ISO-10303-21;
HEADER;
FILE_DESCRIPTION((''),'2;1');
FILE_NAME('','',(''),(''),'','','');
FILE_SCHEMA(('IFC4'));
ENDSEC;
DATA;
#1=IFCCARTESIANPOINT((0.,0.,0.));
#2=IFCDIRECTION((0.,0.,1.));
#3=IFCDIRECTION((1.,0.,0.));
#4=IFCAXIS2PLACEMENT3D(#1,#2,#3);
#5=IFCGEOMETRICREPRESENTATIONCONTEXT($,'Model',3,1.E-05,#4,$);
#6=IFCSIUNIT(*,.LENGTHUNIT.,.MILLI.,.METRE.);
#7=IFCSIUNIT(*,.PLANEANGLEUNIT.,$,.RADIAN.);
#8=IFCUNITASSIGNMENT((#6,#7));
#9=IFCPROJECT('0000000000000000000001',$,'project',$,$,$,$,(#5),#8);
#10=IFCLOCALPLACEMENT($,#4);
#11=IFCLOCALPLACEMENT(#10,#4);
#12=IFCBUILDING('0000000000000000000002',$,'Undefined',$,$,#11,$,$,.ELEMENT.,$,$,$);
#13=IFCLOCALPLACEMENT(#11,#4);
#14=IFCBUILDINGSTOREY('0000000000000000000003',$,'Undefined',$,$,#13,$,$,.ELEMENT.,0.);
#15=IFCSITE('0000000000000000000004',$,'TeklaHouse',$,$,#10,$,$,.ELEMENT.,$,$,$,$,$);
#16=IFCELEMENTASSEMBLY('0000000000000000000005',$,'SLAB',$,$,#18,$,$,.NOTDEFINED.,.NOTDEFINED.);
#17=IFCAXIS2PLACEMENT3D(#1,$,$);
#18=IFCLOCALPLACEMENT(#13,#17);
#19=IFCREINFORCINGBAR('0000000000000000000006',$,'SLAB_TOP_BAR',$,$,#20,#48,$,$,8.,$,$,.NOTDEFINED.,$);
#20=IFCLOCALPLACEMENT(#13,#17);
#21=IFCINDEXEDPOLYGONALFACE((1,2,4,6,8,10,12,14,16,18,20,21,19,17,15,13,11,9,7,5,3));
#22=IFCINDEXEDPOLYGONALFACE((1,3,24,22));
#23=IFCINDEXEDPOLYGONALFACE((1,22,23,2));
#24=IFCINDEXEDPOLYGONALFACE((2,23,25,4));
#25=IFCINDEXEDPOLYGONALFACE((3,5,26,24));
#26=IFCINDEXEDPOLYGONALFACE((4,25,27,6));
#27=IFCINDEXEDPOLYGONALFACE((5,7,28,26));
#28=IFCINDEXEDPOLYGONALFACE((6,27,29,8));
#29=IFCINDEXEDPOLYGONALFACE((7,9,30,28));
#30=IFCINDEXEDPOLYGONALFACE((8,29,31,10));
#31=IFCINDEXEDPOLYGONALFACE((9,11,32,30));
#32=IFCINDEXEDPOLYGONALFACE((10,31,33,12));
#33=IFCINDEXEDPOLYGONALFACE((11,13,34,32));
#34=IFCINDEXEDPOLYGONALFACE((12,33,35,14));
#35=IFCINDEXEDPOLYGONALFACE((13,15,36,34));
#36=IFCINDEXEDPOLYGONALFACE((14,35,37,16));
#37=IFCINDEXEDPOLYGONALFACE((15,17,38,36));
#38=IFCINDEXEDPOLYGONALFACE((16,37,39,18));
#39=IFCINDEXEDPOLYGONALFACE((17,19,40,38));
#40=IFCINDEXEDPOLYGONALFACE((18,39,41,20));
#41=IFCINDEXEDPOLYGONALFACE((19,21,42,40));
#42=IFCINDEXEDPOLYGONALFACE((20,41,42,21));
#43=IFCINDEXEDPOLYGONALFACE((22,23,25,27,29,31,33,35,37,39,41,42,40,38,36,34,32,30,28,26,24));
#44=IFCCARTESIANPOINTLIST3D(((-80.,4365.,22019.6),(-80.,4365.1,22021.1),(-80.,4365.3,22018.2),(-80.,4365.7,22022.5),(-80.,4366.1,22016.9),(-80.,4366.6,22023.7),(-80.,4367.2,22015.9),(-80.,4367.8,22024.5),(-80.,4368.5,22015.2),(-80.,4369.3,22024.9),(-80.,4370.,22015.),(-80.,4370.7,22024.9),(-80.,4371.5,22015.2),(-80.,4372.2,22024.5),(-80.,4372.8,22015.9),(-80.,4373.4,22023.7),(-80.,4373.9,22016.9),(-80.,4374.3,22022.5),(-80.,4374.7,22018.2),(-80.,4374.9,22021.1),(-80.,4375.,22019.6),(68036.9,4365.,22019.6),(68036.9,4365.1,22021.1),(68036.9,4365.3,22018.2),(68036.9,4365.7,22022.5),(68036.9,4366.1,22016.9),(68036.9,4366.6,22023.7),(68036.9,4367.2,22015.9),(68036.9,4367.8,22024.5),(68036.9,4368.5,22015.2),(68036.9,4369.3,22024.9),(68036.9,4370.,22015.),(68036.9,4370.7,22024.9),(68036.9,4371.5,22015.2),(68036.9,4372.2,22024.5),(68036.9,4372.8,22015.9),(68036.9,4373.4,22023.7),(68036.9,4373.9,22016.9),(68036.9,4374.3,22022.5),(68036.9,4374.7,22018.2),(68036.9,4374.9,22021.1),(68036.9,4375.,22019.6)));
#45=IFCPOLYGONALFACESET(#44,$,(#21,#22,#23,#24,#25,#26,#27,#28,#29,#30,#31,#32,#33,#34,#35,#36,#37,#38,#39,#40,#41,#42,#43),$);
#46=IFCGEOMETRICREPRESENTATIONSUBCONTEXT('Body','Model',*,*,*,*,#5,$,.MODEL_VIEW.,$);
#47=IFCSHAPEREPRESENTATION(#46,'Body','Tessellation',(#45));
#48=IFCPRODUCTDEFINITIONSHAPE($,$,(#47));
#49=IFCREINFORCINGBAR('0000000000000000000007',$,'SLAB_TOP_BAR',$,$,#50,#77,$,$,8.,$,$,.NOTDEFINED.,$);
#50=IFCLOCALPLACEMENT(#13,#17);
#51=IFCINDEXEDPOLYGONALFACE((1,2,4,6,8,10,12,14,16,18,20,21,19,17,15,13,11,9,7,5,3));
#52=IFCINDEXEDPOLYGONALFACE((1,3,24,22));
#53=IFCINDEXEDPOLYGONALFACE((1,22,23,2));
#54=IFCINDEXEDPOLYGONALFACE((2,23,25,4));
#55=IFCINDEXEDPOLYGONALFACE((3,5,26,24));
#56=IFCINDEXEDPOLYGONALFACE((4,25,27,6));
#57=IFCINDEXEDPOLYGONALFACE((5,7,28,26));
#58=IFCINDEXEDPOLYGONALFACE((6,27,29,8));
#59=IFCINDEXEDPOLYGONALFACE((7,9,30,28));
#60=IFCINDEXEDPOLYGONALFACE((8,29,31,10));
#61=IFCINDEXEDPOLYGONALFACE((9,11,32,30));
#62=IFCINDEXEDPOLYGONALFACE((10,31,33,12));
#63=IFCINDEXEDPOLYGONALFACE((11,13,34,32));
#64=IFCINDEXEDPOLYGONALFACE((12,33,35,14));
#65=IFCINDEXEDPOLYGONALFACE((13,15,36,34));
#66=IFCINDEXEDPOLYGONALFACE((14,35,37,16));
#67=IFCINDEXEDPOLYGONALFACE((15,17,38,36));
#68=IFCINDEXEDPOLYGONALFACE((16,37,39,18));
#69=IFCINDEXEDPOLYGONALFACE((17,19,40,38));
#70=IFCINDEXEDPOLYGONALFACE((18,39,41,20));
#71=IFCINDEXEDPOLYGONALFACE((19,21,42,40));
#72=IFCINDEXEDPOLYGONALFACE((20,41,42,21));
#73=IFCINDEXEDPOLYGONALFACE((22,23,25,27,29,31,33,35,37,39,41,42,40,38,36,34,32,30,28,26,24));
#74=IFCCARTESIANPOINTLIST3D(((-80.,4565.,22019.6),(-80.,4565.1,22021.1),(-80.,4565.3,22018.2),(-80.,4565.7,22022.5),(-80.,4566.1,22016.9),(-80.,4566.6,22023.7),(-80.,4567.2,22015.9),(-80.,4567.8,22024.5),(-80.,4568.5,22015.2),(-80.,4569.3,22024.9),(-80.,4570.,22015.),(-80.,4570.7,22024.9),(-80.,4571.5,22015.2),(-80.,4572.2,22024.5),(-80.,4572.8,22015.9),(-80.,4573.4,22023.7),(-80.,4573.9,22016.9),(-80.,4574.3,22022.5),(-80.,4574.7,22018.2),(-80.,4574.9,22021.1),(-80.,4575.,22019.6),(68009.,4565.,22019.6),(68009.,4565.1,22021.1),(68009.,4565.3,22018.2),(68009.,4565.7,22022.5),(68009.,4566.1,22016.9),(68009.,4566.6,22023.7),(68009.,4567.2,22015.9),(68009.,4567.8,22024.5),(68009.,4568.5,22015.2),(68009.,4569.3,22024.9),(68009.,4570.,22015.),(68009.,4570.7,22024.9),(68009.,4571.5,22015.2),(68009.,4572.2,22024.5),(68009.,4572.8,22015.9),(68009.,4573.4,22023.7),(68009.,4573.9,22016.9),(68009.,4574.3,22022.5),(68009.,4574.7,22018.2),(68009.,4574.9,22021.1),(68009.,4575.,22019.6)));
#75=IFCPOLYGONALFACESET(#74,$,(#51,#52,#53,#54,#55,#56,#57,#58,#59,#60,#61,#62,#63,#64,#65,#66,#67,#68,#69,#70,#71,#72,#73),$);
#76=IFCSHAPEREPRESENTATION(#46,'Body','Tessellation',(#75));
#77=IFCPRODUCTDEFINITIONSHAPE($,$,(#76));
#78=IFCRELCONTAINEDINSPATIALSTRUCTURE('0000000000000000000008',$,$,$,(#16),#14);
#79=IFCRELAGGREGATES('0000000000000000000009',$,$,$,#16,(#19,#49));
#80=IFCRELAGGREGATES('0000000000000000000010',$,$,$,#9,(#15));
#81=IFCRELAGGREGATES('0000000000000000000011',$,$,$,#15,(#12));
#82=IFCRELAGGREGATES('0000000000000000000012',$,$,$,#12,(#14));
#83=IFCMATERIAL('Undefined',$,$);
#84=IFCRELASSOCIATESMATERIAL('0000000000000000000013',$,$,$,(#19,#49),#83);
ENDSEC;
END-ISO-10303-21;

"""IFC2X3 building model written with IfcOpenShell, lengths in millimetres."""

from ifc_helpers import new_model, entity, si_unit, frame, origin_with_axes, place, context, subcontext, project, spatial, source, transform, mapped, material, element, aggregate, save


model = new_model("IFC2X3")

# Units and contexts
model_context = context("Model", 3, precision=1e-05, world=origin_with_axes())
body_context = subcontext(model_context, "Body", "Model", "MODEL_VIEW")
ifc_project = project(units=[si_unit("LENGTHUNIT", "METRE", prefix="MILLI"), si_unit("PLANEANGLEUNIT", "RADIAN")], contexts=[model_context])

# Site, building, storey
site_placement = place(None, origin_with_axes())
site = spatial("IfcSite", under=ifc_project, at=site_placement, Name="TeklaHouse", CompositionType="ELEMENT")
building_placement = place(site_placement, origin_with_axes())
building = spatial("IfcBuilding", under=site, at=building_placement, Name="Undefined", CompositionType="ELEMENT")
storey_placement = place(building_placement, origin_with_axes())
storey = spatial("IfcBuildingStorey", under=building, at=storey_placement, Name="Undefined", CompositionType="ELEMENT", Elevation=0.0)

# Shared definitions
ifc_material_1 = material(Name="Undefined")

# Element assembly, reinforcing bars
assembly_1_placement = place(storey_placement, origin_with_axes())
assembly_1 = element("IfcElementAssembly", 1, at=assembly_1_placement, inside=storey, Name="SLAB", AssemblyPlace="NOTDEFINED", PredefinedType="NOTDEFINED")
shared_shape_1 = source(origin_with_axes(), body_context, "Body", "AdvancedSweptSolid", [
    entity("IfcSweptDiskSolid", entity("IfcTrimmedCurve", entity("IfcLine", entity("IfcCartesianPoint", [0.0, 0.0, 0.0]), entity("IfcVector", entity("IfcDirection", [1.0, 0.0, 0.0]), 1.0)), [entity("IfcParameterValue", 0.0)], [entity("IfcParameterValue", 68116.890652)], True, "PARAMETER"), 5.0, None, 0.0, 68116.9),
])
reinforcing_bar_1_placement = place(assembly_1_placement, frame((68036.9, 4370.0, 22020.0), z_axis=(0.0, 0.0, -1.0), x_axis=(-1.0, 0.0, 0.0)))
reinforcing_bar_1 = element("IfcReinforcingBar", 2, at=reinforcing_bar_1_placement, material=ifc_material_1, Name="SLAB_TOP_BAR", BarRole="NOTDEFINED", NominalDiameter=8.0, context=body_context, shape_type="MappedRepresentation", body=[
    mapped(shared_shape_1, transform((0.0, 0.0, 0.0))),
])
shared_shape_2 = source(origin_with_axes(), body_context, "Body", "AdvancedSweptSolid", [
    entity("IfcSweptDiskSolid", entity("IfcTrimmedCurve", entity("IfcLine", entity("IfcCartesianPoint", [0.0, 0.0, 0.0]), entity("IfcVector", entity("IfcDirection", [1.0, 0.0, 0.0]), 1.0)), [entity("IfcParameterValue", 0.0)], [entity("IfcParameterValue", 68089.044195)], True, "PARAMETER"), 5.0, None, 0.0, 68089.0),
])
reinforcing_bar_2_placement = place(assembly_1_placement, frame((68009.0, 4570.0, 22020.0), z_axis=(0.0, 0.0, -1.0), x_axis=(-1.0, 0.0, 0.0)))
reinforcing_bar_2 = element("IfcReinforcingBar", 3, at=reinforcing_bar_2_placement, material=ifc_material_1, Name="SLAB_TOP_BAR", BarRole="NOTDEFINED", NominalDiameter=8.0, context=body_context, shape_type="MappedRepresentation", body=[
    mapped(shared_shape_2, transform((0.0, 0.0, 0.0))),
])
aggregate(assembly_1, [reinforcing_bar_1, reinforcing_bar_2])

save(model, "model.ifc")
